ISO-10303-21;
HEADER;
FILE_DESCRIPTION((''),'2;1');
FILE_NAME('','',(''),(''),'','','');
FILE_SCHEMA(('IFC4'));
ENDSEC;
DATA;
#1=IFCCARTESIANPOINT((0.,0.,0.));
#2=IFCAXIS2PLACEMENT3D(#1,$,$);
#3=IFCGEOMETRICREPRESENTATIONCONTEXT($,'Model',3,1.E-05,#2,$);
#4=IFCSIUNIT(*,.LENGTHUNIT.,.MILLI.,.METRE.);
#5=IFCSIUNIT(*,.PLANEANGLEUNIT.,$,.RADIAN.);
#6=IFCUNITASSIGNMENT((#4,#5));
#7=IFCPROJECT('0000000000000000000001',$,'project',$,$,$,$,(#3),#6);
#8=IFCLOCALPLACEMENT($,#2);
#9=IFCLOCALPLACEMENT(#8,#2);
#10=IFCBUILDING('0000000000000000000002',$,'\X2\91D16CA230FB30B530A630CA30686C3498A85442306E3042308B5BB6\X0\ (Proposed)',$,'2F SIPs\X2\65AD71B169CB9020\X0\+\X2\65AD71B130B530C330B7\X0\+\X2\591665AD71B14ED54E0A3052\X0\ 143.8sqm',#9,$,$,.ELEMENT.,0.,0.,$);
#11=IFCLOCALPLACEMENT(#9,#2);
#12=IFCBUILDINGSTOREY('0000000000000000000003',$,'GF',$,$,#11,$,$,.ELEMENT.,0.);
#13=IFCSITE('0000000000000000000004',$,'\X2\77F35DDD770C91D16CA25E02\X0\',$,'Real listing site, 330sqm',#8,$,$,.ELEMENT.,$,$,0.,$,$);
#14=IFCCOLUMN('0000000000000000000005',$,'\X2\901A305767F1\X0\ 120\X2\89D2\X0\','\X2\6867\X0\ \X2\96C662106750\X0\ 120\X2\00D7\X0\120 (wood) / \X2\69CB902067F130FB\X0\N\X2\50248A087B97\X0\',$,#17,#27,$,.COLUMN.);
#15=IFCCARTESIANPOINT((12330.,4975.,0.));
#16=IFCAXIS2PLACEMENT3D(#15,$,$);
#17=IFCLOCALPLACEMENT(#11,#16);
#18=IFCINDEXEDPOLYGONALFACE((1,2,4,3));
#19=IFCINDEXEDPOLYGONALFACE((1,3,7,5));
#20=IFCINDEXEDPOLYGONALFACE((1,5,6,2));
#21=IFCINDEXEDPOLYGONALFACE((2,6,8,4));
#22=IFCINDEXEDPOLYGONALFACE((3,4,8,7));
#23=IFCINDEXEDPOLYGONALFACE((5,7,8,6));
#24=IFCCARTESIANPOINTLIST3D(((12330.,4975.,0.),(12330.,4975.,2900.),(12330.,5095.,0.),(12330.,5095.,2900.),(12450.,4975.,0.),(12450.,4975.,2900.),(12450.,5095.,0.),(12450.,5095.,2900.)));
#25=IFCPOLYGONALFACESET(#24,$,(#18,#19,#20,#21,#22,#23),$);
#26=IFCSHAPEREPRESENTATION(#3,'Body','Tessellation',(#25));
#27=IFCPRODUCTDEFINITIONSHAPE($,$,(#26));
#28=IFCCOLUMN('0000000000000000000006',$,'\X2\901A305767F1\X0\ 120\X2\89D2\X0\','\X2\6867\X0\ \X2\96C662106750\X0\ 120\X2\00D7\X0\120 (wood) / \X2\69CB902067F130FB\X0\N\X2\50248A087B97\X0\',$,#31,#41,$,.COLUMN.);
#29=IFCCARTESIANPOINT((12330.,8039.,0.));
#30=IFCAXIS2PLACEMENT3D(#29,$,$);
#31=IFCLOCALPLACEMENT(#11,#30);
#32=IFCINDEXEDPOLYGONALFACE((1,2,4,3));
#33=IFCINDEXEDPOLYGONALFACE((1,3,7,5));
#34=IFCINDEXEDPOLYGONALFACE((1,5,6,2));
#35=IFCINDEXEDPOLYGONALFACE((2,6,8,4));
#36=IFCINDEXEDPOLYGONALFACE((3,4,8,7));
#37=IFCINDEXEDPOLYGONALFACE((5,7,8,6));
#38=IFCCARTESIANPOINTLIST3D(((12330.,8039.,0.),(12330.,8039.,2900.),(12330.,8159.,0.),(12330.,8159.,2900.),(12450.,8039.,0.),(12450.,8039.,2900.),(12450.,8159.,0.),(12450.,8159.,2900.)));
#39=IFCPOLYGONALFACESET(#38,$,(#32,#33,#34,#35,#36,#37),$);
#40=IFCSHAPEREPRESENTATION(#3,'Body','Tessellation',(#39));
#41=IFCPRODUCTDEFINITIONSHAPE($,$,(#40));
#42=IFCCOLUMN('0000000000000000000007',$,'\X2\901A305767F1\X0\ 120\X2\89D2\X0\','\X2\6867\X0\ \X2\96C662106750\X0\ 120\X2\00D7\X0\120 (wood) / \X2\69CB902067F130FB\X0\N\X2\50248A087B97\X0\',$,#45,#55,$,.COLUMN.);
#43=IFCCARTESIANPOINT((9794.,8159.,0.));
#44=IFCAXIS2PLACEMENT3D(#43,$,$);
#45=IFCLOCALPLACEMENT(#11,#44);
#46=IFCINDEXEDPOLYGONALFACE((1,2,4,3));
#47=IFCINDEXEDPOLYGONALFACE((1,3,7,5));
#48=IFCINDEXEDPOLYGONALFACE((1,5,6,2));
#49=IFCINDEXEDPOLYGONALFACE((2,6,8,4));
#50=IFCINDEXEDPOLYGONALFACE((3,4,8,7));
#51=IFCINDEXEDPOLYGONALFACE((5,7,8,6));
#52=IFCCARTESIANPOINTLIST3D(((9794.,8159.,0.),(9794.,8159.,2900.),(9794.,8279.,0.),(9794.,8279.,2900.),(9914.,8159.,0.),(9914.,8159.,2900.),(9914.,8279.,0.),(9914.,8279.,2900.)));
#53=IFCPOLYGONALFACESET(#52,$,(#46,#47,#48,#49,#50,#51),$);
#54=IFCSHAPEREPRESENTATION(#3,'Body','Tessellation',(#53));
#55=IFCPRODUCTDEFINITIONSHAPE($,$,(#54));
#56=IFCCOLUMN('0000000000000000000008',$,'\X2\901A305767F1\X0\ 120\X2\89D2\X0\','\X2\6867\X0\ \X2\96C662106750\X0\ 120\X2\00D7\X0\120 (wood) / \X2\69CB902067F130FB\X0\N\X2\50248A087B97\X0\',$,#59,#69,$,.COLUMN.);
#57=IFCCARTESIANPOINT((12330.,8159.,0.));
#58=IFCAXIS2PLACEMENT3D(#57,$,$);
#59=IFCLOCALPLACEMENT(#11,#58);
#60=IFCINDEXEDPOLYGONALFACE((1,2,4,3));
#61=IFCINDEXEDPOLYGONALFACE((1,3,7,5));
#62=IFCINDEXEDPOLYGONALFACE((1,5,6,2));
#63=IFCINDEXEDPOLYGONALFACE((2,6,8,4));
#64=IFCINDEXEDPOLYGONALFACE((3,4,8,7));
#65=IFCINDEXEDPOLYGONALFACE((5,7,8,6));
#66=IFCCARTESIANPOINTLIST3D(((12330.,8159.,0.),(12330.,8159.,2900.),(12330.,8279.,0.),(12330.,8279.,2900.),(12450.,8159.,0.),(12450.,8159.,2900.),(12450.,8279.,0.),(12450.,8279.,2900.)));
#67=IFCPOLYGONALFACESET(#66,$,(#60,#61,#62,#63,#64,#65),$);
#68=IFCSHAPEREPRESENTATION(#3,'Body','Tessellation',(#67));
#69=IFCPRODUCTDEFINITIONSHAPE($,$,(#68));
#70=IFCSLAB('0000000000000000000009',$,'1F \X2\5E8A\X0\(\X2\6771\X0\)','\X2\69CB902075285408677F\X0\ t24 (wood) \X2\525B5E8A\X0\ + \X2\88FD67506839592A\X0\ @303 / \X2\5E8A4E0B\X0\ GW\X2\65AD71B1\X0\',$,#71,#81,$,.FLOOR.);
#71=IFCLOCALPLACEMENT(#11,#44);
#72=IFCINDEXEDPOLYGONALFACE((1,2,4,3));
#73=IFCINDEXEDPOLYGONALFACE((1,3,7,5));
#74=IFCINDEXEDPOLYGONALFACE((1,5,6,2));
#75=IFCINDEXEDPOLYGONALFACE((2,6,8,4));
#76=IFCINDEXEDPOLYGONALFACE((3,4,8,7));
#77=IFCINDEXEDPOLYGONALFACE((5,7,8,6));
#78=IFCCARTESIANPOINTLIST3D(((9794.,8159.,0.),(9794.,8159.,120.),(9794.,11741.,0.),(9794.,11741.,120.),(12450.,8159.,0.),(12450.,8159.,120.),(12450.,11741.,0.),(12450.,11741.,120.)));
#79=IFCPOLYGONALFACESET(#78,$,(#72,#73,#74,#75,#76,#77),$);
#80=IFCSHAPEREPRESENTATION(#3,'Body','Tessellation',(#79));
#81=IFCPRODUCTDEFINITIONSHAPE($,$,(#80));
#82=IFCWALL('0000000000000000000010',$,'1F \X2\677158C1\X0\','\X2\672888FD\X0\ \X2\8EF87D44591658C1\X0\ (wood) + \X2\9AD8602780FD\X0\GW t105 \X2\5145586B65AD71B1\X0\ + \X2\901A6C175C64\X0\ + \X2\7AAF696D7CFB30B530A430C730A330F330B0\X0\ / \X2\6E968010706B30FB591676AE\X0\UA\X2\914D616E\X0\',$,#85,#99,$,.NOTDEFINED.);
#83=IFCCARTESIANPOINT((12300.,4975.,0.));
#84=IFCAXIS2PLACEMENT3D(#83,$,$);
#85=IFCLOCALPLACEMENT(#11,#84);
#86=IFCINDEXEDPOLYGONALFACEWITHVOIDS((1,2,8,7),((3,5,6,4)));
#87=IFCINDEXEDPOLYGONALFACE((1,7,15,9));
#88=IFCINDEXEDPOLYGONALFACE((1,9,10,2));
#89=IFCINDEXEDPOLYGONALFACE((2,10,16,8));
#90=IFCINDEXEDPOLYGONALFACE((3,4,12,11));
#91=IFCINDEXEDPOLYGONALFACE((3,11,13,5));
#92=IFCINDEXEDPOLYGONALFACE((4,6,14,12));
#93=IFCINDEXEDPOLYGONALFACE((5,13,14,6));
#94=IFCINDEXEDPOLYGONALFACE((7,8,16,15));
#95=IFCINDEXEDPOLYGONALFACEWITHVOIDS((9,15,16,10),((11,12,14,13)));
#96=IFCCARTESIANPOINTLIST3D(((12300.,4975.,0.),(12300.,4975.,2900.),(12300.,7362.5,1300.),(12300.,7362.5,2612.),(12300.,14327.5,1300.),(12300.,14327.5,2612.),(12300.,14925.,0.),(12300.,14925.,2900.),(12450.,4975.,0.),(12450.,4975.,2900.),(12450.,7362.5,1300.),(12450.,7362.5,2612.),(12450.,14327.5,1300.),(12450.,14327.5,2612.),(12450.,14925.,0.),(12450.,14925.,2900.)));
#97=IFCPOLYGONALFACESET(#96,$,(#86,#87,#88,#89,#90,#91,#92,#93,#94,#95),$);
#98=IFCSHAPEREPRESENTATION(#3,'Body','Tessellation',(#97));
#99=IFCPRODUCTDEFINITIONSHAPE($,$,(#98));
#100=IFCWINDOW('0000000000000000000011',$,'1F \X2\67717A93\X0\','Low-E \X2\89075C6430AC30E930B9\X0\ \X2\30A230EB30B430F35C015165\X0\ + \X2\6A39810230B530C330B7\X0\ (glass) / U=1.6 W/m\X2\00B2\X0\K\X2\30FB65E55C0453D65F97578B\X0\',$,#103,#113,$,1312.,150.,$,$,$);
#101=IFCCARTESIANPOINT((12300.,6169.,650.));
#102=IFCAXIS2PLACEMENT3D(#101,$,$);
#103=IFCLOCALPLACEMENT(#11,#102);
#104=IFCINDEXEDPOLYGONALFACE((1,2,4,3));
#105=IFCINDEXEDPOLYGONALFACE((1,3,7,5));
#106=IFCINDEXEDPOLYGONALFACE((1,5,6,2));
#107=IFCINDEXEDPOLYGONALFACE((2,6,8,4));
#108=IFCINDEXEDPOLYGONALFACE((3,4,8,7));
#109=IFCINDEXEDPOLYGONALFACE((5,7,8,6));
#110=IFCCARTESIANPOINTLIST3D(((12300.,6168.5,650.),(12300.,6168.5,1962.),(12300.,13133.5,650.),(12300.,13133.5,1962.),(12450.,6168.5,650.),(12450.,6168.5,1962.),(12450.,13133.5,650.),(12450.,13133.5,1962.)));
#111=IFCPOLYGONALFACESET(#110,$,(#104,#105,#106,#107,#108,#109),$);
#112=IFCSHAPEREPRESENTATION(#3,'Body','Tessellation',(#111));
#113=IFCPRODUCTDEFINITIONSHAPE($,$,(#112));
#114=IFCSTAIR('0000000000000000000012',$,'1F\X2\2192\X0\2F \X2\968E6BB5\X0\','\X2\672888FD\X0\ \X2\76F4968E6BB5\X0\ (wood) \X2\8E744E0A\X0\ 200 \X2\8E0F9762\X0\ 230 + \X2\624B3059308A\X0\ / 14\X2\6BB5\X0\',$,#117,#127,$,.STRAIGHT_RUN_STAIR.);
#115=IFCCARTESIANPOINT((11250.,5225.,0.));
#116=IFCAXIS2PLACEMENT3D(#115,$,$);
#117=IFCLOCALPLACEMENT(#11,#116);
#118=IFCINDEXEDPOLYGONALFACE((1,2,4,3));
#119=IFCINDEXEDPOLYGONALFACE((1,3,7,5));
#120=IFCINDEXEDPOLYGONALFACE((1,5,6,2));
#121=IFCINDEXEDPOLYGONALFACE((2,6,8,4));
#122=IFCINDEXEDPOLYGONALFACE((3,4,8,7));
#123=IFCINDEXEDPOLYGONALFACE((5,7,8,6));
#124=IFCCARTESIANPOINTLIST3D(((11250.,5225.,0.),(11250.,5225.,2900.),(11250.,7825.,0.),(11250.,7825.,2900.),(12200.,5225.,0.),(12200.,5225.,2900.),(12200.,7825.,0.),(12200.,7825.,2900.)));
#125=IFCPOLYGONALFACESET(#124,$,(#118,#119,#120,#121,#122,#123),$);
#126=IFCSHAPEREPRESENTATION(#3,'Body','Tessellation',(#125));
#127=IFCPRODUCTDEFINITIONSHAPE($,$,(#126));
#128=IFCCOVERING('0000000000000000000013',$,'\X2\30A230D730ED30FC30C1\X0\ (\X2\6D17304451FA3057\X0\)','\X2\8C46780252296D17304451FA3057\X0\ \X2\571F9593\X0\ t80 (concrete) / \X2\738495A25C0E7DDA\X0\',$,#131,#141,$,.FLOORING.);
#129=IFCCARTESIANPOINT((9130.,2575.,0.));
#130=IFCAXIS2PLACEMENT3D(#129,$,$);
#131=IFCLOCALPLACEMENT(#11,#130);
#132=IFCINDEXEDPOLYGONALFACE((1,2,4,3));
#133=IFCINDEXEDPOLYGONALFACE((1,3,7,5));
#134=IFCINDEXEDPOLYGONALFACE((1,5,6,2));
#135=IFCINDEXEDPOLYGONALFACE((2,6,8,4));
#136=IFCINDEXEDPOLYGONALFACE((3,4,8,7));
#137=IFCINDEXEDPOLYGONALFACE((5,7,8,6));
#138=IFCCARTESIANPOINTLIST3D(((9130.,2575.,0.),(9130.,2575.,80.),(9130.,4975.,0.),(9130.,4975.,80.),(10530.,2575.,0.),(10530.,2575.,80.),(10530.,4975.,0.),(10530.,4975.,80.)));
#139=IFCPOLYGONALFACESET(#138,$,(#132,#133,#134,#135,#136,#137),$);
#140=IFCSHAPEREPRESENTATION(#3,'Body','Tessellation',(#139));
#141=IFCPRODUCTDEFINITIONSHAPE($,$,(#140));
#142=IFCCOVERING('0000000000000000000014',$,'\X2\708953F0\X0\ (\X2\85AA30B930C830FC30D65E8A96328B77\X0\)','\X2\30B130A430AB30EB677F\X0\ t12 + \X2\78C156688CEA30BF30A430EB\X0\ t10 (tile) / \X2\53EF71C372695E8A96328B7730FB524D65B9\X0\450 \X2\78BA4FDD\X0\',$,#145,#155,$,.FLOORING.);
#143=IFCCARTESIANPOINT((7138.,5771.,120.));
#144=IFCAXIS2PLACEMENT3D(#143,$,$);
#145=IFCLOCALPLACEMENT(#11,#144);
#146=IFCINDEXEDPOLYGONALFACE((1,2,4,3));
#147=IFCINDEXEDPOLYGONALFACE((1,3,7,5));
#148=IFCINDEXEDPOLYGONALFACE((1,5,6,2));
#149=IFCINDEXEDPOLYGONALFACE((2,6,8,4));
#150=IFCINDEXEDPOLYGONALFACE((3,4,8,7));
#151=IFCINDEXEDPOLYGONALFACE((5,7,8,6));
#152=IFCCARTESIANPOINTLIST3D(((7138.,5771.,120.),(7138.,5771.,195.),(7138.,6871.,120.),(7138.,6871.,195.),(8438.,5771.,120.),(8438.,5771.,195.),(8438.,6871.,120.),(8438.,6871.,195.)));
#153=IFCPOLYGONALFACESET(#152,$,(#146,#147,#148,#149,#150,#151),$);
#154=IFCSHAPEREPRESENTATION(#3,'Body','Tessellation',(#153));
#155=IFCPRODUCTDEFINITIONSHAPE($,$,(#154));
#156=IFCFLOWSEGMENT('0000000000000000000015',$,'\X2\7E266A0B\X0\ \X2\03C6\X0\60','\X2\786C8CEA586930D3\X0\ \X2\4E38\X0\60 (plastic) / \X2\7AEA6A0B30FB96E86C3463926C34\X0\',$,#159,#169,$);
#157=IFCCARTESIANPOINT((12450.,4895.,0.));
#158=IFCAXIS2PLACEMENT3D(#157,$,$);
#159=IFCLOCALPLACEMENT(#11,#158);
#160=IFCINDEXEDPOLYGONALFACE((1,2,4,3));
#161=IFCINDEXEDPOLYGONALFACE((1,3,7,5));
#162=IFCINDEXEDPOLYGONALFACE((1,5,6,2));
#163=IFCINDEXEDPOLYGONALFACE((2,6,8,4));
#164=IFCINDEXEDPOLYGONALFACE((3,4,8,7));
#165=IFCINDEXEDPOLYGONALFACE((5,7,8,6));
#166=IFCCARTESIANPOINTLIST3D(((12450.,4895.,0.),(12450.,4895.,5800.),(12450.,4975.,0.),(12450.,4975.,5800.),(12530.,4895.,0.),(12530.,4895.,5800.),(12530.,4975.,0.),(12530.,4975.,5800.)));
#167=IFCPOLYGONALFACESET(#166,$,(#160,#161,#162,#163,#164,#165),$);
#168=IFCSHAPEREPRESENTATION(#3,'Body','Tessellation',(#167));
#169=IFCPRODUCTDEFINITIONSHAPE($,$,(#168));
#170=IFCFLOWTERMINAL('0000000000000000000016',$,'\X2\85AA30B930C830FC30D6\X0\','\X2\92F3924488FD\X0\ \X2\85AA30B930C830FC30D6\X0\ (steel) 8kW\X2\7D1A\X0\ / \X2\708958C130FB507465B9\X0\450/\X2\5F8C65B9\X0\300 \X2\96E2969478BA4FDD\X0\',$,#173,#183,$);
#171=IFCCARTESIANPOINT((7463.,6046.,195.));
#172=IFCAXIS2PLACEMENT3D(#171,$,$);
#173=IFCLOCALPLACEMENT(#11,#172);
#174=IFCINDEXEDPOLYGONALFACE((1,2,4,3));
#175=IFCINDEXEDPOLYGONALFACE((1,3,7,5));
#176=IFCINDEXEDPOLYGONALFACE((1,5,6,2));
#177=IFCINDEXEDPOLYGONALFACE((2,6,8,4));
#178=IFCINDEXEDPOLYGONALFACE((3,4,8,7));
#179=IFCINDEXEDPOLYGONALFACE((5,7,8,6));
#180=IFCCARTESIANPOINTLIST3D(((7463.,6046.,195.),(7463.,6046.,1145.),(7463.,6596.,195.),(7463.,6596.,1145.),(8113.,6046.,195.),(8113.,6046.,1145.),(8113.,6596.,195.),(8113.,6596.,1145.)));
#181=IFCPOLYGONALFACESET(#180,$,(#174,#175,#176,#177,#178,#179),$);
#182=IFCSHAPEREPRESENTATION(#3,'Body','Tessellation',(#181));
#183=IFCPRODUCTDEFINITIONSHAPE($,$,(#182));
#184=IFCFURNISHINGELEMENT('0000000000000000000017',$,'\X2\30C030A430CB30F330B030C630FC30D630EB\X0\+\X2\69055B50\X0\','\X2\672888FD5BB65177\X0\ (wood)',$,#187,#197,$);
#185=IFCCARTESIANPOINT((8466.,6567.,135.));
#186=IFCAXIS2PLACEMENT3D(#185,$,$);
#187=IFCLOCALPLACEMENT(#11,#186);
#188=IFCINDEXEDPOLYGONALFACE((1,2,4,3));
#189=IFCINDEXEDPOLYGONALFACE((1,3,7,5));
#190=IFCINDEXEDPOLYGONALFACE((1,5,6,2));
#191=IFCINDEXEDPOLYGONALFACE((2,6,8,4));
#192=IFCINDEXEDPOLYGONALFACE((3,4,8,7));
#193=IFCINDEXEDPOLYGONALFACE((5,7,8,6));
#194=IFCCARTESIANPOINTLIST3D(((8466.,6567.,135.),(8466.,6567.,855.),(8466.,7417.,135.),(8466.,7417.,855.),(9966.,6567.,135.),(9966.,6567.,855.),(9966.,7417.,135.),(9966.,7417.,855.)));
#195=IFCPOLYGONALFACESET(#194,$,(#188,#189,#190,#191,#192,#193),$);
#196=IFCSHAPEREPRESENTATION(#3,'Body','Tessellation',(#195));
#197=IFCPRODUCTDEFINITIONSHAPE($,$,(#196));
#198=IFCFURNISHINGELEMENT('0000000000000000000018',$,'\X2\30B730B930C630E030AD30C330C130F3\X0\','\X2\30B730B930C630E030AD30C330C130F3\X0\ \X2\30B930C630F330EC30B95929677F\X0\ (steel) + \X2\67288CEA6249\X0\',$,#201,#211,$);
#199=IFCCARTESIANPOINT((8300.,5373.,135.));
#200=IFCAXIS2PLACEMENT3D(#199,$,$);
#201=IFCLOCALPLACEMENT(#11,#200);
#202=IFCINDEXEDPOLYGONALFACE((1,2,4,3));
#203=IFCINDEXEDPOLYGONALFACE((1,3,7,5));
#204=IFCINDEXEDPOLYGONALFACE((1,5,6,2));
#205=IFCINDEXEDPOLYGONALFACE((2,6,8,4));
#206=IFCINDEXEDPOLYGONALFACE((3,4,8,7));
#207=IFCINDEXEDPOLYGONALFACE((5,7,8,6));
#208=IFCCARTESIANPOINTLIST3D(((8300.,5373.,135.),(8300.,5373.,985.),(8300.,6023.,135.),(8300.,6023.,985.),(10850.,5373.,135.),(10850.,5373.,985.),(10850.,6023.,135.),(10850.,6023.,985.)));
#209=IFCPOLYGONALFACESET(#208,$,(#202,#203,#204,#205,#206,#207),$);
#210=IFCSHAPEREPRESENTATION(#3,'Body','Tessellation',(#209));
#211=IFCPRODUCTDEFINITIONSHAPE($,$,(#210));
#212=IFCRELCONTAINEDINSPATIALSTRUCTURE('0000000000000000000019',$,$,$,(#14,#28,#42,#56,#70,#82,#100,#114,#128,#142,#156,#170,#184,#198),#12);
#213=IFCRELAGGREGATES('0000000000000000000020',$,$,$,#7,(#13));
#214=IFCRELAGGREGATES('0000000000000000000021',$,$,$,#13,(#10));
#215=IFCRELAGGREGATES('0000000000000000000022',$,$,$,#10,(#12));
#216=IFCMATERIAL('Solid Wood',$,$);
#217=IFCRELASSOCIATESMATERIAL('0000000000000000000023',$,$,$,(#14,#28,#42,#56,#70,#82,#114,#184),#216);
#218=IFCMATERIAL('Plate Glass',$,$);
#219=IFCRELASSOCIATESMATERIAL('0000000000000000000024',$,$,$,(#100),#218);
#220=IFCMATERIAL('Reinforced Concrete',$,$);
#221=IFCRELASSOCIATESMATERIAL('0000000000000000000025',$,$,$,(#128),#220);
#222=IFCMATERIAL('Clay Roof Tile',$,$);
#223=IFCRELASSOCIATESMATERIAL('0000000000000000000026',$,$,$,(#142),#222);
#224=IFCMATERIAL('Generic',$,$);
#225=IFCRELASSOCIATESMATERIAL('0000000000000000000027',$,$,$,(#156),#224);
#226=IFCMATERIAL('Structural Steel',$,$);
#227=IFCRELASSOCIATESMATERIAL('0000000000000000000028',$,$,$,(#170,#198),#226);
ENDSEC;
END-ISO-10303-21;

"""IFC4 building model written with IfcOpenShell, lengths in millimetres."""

from ifc_helpers import new_model, si_unit, frame, frame_2d, origin, place, context, project, spatial, rectangle, extrude, material, element, fill, save


model = new_model("IFC4")

# Units and contexts
model_context = context("Model", 3, precision=1e-05, world=origin())
ifc_project = project(units=[si_unit("LENGTHUNIT", "METRE", prefix="MILLI"), si_unit("PLANEANGLEUNIT", "RADIAN")], contexts=[model_context])

# Site, building, storey
site_placement = place(None, origin())
site = spatial("IfcSite", under=ifc_project, at=site_placement, Name="石川県金沢市", ObjectType="Real listing site, 330sqm", CompositionType="ELEMENT", RefElevation=0.0)
building_placement = place(site_placement, origin())
building = spatial("IfcBuilding", under=site, at=building_placement, Name="金沢・サウナと水風呂のある家 (Proposed)", ObjectType="2F SIPs断熱構造+断熱サッシ+外断熱仕上げ 143.8sqm", CompositionType="ELEMENT", ElevationOfRefHeight=0.0, ElevationOfTerrain=0.0)
storey_placement = place(building_placement, origin())
storey = spatial("IfcBuildingStorey", under=building, at=storey_placement, Name="GF", CompositionType="ELEMENT", Elevation=0.0)

# Columns
ifc_material_1 = material(Name="Solid Wood")
column_1_placement = place(storey_placement, frame((12330.0, 4975.0, 0.0)))
element("IfcColumn", 1, at=column_1_placement, inside=storey, material=ifc_material_1, Name="通し柱 120角", Description="桧 集成材 120×120 (wood) / 構造柱・N値計算", PredefinedType="COLUMN", context=model_context, shape_type="SweptSolid", body=[
    extrude(rectangle(XDim=120.0, YDim=120.0, at=frame_2d((60.0, 60.0))), frame((12330.0, 4975.0, 0.0)), (0.0, 0.0, 1.0), 2900.0),
])
column_2_placement = place(storey_placement, frame((12330.0, 8039.0, 0.0)))
element("IfcColumn", 2, at=column_2_placement, inside=storey, material=ifc_material_1, Name="通し柱 120角", Description="桧 集成材 120×120 (wood) / 構造柱・N値計算", PredefinedType="COLUMN", context=model_context, shape_type="SweptSolid", body=[
    extrude(rectangle(XDim=120.0, YDim=120.0, at=frame_2d((60.0, 60.0))), frame((12330.0, 8039.0, 0.0)), (0.0, 0.0, 1.0), 2900.0),
])
column_3_placement = place(storey_placement, frame((9794.0, 8159.0, 0.0)))
element("IfcColumn", 3, at=column_3_placement, inside=storey, material=ifc_material_1, Name="通し柱 120角", Description="桧 集成材 120×120 (wood) / 構造柱・N値計算", PredefinedType="COLUMN", context=model_context, shape_type="SweptSolid", body=[
    extrude(rectangle(XDim=120.0, YDim=120.0, at=frame_2d((60.0, 60.0))), frame((9794.0, 8159.0, 0.0)), (0.0, 0.0, 1.0), 2900.0),
])
column_4_placement = place(storey_placement, frame((12330.0, 8159.0, 0.0)))
element("IfcColumn", 4, at=column_4_placement, inside=storey, material=ifc_material_1, Name="通し柱 120角", Description="桧 集成材 120×120 (wood) / 構造柱・N値計算", PredefinedType="COLUMN", context=model_context, shape_type="SweptSolid", body=[
    extrude(rectangle(XDim=120.0, YDim=120.0, at=frame_2d((60.0, 60.0))), frame((12330.0, 8159.0, 0.0)), (0.0, 0.0, 1.0), 2900.0),
])

# Slab
slab_placement = place(storey_placement, frame((9794.0, 8159.0, 0.0)))
element("IfcSlab", 5, at=slab_placement, inside=storey, material=ifc_material_1, Name="1F 床(東)", Description="構造用合板 t24 (wood) 剛床 + 製材根太 @303 / 床下 GW断熱", PredefinedType="FLOOR", context=model_context, shape_type="SweptSolid", body=[
    extrude(rectangle(XDim=2656.0, YDim=3582.0, at=frame_2d((1328.0, 1791.0))), frame((9794.0, 8159.0, 0.0)), (0.0, 0.0, 1.0), 120.0),
])

# Wall, opening, window
wall_1_placement = place(storey_placement, frame((12300.0, 4975.0, 0.0)))
wall_1 = element("IfcWall", 6, at=wall_1_placement, inside=storey, material=ifc_material_1, Name="1F 東壁", Description="木製 軸組外壁 (wood) + 高性能GW t105 充填断熱 + 通気層 + 窯業系サイディング / 準耐火・外皮UA配慮", PredefinedType="NOTDEFINED", context=model_context, shape_type="SweptSolid", body=[
    extrude(rectangle(XDim=150.0, YDim=9950.0, at=frame_2d((75.0, 4975.0))), frame((12300.0, 4975.0, 0.0)), (0.0, 0.0, 1.0), 2900.0),
])
opening_placement = place(storey_placement, frame((12300.0, 6169.0, 650.0)))
opening = element("IfcOpeningElement", 7, at=opening_placement, cuts=wall_1, PredefinedType="NOTDEFINED", context=model_context, shape_type="SweptSolid", body=[
    extrude(rectangle(XDim=150.0, YDim=6965.0, at=frame_2d((75.0, 3482.0))), frame((12300.0, 6169.0, 650.0)), (0.0, 0.0, 1.0), 1312.0),
])
ifc_material_2 = material(Name="Plate Glass")
window_placement = place(storey_placement, frame((12300.0, 6169.0, 650.0)))
window = element("IfcWindow", 8, at=window_placement, inside=storey, material=ifc_material_2, Name="1F 東窓", Description="Low-E 複層ガラス アルゴン封入 + 樹脂サッシ (glass) / U=1.6 W/m²K・日射取得型", OverallHeight=1312.0, OverallWidth=150.0, context=model_context, shape_type="SweptSolid", body=[
    extrude(rectangle(XDim=150.0, YDim=6965.0, at=frame_2d((75.0, 3482.0))), frame((12300.0, 6169.0, 650.0)), (0.0, 0.0, 1.0), 1312.0),
])
fill(opening, window)

# Stair
stair_placement = place(storey_placement, frame((11250.0, 5225.0, 0.0)))
element("IfcStair", 9, at=stair_placement, inside=storey, material=ifc_material_1, Name="1F→2F 階段", Description="木製 直階段 (wood) 蹴上 200 踏面 230 + 手すり / 14段", PredefinedType="STRAIGHT_RUN_STAIR", context=model_context, shape_type="SweptSolid", body=[
    extrude(rectangle(XDim=950.0, YDim=2600.0, at=frame_2d((475.0, 1300.0))), frame((11250.0, 5225.0, 0.0)), (0.0, 0.0, 1.0), 2900.0),
])

# Coverings
ifc_material_3 = material(Name="Reinforced Concrete")
covering_1_placement = place(storey_placement, frame((9130.0, 2575.0, 0.0)))
element("IfcCovering", 10, at=covering_1_placement, inside=storey, material=ifc_material_3, Name="アプローチ (洗い出し)", Description="豆砂利洗い出し 土間 t80 (concrete) / 玄関導線", PredefinedType="FLOORING", context=model_context, shape_type="SweptSolid", body=[
    extrude(rectangle(XDim=1400.0, YDim=2400.0, at=frame_2d((700.0, 1200.0))), frame((9130.0, 2575.0, 0.0)), (0.0, 0.0, 1.0), 80.0),
])
ifc_material_4 = material(Name="Clay Roof Tile")
covering_2_placement = place(storey_placement, frame((7138.0, 5771.0, 120.0)))
element("IfcCovering", 11, at=covering_2_placement, inside=storey, material=ifc_material_4, Name="炉台 (薪ストーブ床防護)", Description="ケイカル板 t12 + 磁器質タイル t10 (tile) / 可燃物床防護・前方450 確保", PredefinedType="FLOORING", context=model_context, shape_type="SweptSolid", body=[
    extrude(rectangle(XDim=1300.0, YDim=1100.0, at=frame_2d((650.0, 550.0))), frame((7138.0, 5771.0, 120.0)), (0.0, 0.0, 1.0), 75.0),
])

# Flow segment
ifc_material_5 = material(Name="Generic")
flow_segment_placement = place(storey_placement, frame((12450.0, 4895.0, 0.0)))
element("IfcFlowSegment", 12, at=flow_segment_placement, inside=storey, material=ifc_material_5, Name="縦樋 φ60", Description="硬質塩ビ 丸60 (plastic) / 竪樋・雨水排水", context=model_context, shape_type="SweptSolid", body=[
    extrude(rectangle(XDim=80.0, YDim=80.0, at=frame_2d((40.0, 40.0))), frame((12450.0, 4895.0, 0.0)), (0.0, 0.0, 1.0), 5800.0),
])

# Flow terminal
ifc_material_6 = material(Name="Structural Steel")
flow_terminal_placement = place(storey_placement, frame((7463.0, 6046.0, 195.0)))
element("IfcFlowTerminal", 13, at=flow_terminal_placement, inside=storey, material=ifc_material_6, Name="薪ストーブ", Description="鋳鉄製 薪ストーブ (steel) 8kW級 / 炉壁・側方450/後方300 離隔確保", context=model_context, shape_type="SweptSolid", body=[
    extrude(rectangle(XDim=650.0, YDim=550.0, at=frame_2d((325.0, 275.0))), frame((7463.0, 6046.0, 195.0)), (0.0, 0.0, 1.0), 950.0),
])

# Furnishing elements
furnishing_1_placement = place(storey_placement, frame((8466.0, 6567.0, 135.0)))
element("IfcFurnishingElement", 14, at=furnishing_1_placement, inside=storey, material=ifc_material_1, Name="ダイニングテーブル+椅子", Description="木製家具 (wood)", context=model_context, shape_type="SweptSolid", body=[
    extrude(rectangle(XDim=1500.0, YDim=850.0, at=frame_2d((750.0, 425.0))), frame((8466.0, 6567.0, 135.0)), (0.0, 0.0, 1.0), 720.0),
])
furnishing_2_placement = place(storey_placement, frame((8300.0, 5373.0, 135.0)))
element("IfcFurnishingElement", 15, at=furnishing_2_placement, inside=storey, material=ifc_material_6, Name="システムキッチン", Description="システムキッチン ステンレス天板 (steel) + 木質扉", context=model_context, shape_type="SweptSolid", body=[
    extrude(rectangle(XDim=2550.0, YDim=650.0, at=frame_2d((1275.0, 325.0))), frame((8300.0, 5373.0, 135.0)), (0.0, 0.0, 1.0), 850.0),
])

save(model, "model.ifc")
